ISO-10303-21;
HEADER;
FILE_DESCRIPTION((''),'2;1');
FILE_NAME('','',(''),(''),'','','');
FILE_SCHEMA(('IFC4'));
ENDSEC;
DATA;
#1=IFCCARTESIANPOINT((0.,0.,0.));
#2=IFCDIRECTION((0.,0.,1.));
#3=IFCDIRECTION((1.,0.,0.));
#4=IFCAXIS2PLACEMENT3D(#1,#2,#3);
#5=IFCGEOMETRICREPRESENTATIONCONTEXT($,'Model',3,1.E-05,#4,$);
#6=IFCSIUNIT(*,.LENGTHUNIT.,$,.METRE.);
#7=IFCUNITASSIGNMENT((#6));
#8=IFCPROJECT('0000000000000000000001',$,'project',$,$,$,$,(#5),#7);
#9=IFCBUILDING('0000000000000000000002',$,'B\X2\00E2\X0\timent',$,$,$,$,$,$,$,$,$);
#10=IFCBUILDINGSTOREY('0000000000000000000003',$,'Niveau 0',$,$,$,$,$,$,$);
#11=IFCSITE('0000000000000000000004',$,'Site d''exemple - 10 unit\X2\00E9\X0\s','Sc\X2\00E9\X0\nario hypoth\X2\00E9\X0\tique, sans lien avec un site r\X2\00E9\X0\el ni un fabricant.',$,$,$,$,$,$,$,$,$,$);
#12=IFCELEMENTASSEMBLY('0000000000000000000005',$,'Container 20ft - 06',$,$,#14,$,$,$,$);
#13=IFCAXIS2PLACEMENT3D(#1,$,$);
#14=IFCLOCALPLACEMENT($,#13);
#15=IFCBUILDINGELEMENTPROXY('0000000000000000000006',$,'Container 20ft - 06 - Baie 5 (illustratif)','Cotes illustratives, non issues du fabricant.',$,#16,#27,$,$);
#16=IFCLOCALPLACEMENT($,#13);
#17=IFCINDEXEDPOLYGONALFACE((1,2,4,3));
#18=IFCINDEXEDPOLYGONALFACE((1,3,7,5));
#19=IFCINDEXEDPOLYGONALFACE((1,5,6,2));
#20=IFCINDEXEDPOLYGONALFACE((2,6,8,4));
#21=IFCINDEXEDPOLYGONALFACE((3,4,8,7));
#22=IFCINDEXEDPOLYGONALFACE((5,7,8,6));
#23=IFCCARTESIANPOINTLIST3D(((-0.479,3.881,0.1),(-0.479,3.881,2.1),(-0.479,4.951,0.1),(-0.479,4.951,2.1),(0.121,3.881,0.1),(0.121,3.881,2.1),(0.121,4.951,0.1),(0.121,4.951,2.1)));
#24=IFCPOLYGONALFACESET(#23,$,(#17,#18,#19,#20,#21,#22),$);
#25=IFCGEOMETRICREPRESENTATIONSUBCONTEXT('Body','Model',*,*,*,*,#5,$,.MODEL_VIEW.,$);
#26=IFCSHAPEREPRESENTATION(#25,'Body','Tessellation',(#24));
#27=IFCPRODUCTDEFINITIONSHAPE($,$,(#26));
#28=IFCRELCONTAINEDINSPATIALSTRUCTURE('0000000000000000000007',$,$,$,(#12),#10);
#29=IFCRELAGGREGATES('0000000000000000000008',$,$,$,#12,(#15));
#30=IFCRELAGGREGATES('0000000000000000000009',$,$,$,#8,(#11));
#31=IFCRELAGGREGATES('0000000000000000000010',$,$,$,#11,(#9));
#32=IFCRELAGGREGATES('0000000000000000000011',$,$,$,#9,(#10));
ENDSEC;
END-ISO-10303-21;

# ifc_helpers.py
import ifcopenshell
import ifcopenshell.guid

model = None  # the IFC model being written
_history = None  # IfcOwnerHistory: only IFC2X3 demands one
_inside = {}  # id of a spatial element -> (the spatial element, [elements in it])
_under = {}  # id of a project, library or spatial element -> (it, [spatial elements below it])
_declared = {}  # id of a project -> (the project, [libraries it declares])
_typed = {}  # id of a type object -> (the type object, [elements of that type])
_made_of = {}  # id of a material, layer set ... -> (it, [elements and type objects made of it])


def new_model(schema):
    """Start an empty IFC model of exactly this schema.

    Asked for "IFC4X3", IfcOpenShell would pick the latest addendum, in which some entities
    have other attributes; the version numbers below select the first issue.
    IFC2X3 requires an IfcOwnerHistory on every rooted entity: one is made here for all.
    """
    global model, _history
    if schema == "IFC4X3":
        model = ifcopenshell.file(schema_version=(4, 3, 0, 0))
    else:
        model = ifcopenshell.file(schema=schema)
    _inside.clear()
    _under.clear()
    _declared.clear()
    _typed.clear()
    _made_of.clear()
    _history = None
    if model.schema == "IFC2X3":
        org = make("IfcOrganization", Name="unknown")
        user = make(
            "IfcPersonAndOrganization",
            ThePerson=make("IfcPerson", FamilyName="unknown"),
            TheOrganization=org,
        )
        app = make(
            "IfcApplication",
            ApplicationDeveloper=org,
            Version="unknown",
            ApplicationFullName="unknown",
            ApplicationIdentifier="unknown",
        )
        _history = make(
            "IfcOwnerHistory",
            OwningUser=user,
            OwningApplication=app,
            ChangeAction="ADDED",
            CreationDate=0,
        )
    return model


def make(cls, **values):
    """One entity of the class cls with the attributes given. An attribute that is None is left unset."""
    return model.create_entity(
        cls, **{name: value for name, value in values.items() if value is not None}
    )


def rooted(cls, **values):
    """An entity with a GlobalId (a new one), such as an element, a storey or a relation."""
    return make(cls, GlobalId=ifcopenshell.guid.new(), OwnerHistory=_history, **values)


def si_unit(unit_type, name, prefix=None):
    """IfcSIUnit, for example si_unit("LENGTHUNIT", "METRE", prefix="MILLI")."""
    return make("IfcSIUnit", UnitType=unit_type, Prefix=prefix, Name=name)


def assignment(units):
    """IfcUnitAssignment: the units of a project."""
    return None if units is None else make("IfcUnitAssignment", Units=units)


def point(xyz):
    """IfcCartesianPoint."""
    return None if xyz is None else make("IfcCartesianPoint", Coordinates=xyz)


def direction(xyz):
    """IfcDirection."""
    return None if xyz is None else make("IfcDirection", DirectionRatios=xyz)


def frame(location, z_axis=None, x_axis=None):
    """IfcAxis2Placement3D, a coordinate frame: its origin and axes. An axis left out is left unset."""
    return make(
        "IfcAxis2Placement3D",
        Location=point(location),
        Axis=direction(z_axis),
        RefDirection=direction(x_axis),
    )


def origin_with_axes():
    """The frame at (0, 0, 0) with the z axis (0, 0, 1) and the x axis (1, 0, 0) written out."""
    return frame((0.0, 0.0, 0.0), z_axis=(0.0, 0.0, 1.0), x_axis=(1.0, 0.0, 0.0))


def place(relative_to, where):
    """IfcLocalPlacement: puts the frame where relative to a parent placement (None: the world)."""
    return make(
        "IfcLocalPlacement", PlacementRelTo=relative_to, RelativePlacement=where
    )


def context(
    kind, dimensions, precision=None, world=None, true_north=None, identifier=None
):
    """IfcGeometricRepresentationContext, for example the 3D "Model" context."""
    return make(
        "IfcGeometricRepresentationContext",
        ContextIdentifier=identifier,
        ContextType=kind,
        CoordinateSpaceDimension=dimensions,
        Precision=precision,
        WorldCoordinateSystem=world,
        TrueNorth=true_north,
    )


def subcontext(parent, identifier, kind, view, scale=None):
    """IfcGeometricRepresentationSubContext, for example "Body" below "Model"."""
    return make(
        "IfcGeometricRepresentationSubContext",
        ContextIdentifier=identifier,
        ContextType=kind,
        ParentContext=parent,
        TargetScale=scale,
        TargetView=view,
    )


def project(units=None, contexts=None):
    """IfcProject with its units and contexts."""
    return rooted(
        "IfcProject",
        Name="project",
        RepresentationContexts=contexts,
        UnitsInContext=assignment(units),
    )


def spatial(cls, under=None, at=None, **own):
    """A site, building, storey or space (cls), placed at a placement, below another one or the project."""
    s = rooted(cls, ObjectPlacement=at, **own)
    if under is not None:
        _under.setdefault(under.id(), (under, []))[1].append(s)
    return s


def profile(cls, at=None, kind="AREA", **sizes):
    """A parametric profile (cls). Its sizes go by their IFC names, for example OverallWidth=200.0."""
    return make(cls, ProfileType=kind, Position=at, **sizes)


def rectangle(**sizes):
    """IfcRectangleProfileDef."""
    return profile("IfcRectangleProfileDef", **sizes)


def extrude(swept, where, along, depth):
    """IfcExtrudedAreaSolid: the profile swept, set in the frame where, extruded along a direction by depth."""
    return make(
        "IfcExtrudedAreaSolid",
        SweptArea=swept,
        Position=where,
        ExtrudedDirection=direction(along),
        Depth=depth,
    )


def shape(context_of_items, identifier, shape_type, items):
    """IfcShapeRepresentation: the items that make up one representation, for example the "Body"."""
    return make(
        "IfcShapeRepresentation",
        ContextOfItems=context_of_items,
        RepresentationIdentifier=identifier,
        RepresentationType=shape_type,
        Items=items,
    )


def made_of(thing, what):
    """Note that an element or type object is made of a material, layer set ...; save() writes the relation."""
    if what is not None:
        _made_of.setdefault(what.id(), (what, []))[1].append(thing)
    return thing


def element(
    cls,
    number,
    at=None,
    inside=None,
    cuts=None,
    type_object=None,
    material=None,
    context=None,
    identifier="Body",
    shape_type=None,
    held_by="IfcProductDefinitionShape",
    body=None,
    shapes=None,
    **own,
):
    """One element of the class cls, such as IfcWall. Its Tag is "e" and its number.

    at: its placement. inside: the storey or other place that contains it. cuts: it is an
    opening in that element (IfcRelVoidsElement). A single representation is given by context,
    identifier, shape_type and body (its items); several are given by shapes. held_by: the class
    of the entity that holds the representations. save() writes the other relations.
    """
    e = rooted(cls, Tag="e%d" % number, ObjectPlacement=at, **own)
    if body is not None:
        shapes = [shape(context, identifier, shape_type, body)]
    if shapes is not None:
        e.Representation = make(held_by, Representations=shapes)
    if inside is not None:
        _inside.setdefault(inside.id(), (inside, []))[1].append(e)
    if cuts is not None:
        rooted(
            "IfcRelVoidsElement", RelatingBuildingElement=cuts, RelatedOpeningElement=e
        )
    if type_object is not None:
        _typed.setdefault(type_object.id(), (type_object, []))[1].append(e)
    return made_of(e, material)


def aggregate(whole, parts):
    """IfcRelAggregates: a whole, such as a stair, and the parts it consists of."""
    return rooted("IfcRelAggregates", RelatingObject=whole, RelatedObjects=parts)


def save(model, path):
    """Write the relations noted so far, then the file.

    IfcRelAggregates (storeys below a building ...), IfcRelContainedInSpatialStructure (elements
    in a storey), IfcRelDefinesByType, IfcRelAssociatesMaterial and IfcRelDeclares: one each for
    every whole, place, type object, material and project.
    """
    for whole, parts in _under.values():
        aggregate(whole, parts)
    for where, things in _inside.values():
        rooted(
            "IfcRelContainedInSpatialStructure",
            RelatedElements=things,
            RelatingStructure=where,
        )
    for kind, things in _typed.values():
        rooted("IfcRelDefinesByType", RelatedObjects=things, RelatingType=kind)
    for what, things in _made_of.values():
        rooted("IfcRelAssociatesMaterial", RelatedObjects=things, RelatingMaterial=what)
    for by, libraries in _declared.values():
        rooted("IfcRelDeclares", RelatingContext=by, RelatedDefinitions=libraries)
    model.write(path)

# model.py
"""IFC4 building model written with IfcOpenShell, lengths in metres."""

from ifc_helpers import new_model, si_unit, frame, origin_with_axes, place, context, subcontext, project, spatial, rectangle, extrude, element, aggregate, save


model = new_model("IFC4")

# Units and contexts
model_context = context("Model", 3, precision=1e-05, world=origin_with_axes())
body_context = subcontext(model_context, "Body", "Model", "MODEL_VIEW")
ifc_project = project(units=[si_unit("LENGTHUNIT", "METRE")], contexts=[model_context])

# Site, building, storey
site = spatial("IfcSite", under=ifc_project, Name="Site d'exemple - 10 unités", Description="Scénario hypothétique, sans lien avec un site réel ni un fabricant.")
building = spatial("IfcBuilding", under=site, Name="Bâtiment")
storey = spatial("IfcBuildingStorey", under=building, Name="Niveau 0")

# Element assembly
assembly_1 = element("IfcElementAssembly", 1, inside=storey, Name="Container 20ft - 06")

# Building element proxy
proxy_1_placement = place(None, frame((-0.179, 4.416, 0.1), z_axis=(0.0, 0.0, 1.0), x_axis=(1.0, 0.0, 0.0)))
proxy_1 = element("IfcBuildingElementProxy", 2, at=proxy_1_placement, Name="Container 20ft - 06 - Baie 5 (illustratif)", Description="Cotes illustratives, non issues du fabricant.", context=body_context, shape_type="SweptSolid", body=[
    extrude(rectangle(XDim=0.6, YDim=1.07), origin_with_axes(), (0.0, 0.0, 1.0), 2.0),
])
aggregate(assembly_1, [proxy_1])

save(model, "model.ifc")
